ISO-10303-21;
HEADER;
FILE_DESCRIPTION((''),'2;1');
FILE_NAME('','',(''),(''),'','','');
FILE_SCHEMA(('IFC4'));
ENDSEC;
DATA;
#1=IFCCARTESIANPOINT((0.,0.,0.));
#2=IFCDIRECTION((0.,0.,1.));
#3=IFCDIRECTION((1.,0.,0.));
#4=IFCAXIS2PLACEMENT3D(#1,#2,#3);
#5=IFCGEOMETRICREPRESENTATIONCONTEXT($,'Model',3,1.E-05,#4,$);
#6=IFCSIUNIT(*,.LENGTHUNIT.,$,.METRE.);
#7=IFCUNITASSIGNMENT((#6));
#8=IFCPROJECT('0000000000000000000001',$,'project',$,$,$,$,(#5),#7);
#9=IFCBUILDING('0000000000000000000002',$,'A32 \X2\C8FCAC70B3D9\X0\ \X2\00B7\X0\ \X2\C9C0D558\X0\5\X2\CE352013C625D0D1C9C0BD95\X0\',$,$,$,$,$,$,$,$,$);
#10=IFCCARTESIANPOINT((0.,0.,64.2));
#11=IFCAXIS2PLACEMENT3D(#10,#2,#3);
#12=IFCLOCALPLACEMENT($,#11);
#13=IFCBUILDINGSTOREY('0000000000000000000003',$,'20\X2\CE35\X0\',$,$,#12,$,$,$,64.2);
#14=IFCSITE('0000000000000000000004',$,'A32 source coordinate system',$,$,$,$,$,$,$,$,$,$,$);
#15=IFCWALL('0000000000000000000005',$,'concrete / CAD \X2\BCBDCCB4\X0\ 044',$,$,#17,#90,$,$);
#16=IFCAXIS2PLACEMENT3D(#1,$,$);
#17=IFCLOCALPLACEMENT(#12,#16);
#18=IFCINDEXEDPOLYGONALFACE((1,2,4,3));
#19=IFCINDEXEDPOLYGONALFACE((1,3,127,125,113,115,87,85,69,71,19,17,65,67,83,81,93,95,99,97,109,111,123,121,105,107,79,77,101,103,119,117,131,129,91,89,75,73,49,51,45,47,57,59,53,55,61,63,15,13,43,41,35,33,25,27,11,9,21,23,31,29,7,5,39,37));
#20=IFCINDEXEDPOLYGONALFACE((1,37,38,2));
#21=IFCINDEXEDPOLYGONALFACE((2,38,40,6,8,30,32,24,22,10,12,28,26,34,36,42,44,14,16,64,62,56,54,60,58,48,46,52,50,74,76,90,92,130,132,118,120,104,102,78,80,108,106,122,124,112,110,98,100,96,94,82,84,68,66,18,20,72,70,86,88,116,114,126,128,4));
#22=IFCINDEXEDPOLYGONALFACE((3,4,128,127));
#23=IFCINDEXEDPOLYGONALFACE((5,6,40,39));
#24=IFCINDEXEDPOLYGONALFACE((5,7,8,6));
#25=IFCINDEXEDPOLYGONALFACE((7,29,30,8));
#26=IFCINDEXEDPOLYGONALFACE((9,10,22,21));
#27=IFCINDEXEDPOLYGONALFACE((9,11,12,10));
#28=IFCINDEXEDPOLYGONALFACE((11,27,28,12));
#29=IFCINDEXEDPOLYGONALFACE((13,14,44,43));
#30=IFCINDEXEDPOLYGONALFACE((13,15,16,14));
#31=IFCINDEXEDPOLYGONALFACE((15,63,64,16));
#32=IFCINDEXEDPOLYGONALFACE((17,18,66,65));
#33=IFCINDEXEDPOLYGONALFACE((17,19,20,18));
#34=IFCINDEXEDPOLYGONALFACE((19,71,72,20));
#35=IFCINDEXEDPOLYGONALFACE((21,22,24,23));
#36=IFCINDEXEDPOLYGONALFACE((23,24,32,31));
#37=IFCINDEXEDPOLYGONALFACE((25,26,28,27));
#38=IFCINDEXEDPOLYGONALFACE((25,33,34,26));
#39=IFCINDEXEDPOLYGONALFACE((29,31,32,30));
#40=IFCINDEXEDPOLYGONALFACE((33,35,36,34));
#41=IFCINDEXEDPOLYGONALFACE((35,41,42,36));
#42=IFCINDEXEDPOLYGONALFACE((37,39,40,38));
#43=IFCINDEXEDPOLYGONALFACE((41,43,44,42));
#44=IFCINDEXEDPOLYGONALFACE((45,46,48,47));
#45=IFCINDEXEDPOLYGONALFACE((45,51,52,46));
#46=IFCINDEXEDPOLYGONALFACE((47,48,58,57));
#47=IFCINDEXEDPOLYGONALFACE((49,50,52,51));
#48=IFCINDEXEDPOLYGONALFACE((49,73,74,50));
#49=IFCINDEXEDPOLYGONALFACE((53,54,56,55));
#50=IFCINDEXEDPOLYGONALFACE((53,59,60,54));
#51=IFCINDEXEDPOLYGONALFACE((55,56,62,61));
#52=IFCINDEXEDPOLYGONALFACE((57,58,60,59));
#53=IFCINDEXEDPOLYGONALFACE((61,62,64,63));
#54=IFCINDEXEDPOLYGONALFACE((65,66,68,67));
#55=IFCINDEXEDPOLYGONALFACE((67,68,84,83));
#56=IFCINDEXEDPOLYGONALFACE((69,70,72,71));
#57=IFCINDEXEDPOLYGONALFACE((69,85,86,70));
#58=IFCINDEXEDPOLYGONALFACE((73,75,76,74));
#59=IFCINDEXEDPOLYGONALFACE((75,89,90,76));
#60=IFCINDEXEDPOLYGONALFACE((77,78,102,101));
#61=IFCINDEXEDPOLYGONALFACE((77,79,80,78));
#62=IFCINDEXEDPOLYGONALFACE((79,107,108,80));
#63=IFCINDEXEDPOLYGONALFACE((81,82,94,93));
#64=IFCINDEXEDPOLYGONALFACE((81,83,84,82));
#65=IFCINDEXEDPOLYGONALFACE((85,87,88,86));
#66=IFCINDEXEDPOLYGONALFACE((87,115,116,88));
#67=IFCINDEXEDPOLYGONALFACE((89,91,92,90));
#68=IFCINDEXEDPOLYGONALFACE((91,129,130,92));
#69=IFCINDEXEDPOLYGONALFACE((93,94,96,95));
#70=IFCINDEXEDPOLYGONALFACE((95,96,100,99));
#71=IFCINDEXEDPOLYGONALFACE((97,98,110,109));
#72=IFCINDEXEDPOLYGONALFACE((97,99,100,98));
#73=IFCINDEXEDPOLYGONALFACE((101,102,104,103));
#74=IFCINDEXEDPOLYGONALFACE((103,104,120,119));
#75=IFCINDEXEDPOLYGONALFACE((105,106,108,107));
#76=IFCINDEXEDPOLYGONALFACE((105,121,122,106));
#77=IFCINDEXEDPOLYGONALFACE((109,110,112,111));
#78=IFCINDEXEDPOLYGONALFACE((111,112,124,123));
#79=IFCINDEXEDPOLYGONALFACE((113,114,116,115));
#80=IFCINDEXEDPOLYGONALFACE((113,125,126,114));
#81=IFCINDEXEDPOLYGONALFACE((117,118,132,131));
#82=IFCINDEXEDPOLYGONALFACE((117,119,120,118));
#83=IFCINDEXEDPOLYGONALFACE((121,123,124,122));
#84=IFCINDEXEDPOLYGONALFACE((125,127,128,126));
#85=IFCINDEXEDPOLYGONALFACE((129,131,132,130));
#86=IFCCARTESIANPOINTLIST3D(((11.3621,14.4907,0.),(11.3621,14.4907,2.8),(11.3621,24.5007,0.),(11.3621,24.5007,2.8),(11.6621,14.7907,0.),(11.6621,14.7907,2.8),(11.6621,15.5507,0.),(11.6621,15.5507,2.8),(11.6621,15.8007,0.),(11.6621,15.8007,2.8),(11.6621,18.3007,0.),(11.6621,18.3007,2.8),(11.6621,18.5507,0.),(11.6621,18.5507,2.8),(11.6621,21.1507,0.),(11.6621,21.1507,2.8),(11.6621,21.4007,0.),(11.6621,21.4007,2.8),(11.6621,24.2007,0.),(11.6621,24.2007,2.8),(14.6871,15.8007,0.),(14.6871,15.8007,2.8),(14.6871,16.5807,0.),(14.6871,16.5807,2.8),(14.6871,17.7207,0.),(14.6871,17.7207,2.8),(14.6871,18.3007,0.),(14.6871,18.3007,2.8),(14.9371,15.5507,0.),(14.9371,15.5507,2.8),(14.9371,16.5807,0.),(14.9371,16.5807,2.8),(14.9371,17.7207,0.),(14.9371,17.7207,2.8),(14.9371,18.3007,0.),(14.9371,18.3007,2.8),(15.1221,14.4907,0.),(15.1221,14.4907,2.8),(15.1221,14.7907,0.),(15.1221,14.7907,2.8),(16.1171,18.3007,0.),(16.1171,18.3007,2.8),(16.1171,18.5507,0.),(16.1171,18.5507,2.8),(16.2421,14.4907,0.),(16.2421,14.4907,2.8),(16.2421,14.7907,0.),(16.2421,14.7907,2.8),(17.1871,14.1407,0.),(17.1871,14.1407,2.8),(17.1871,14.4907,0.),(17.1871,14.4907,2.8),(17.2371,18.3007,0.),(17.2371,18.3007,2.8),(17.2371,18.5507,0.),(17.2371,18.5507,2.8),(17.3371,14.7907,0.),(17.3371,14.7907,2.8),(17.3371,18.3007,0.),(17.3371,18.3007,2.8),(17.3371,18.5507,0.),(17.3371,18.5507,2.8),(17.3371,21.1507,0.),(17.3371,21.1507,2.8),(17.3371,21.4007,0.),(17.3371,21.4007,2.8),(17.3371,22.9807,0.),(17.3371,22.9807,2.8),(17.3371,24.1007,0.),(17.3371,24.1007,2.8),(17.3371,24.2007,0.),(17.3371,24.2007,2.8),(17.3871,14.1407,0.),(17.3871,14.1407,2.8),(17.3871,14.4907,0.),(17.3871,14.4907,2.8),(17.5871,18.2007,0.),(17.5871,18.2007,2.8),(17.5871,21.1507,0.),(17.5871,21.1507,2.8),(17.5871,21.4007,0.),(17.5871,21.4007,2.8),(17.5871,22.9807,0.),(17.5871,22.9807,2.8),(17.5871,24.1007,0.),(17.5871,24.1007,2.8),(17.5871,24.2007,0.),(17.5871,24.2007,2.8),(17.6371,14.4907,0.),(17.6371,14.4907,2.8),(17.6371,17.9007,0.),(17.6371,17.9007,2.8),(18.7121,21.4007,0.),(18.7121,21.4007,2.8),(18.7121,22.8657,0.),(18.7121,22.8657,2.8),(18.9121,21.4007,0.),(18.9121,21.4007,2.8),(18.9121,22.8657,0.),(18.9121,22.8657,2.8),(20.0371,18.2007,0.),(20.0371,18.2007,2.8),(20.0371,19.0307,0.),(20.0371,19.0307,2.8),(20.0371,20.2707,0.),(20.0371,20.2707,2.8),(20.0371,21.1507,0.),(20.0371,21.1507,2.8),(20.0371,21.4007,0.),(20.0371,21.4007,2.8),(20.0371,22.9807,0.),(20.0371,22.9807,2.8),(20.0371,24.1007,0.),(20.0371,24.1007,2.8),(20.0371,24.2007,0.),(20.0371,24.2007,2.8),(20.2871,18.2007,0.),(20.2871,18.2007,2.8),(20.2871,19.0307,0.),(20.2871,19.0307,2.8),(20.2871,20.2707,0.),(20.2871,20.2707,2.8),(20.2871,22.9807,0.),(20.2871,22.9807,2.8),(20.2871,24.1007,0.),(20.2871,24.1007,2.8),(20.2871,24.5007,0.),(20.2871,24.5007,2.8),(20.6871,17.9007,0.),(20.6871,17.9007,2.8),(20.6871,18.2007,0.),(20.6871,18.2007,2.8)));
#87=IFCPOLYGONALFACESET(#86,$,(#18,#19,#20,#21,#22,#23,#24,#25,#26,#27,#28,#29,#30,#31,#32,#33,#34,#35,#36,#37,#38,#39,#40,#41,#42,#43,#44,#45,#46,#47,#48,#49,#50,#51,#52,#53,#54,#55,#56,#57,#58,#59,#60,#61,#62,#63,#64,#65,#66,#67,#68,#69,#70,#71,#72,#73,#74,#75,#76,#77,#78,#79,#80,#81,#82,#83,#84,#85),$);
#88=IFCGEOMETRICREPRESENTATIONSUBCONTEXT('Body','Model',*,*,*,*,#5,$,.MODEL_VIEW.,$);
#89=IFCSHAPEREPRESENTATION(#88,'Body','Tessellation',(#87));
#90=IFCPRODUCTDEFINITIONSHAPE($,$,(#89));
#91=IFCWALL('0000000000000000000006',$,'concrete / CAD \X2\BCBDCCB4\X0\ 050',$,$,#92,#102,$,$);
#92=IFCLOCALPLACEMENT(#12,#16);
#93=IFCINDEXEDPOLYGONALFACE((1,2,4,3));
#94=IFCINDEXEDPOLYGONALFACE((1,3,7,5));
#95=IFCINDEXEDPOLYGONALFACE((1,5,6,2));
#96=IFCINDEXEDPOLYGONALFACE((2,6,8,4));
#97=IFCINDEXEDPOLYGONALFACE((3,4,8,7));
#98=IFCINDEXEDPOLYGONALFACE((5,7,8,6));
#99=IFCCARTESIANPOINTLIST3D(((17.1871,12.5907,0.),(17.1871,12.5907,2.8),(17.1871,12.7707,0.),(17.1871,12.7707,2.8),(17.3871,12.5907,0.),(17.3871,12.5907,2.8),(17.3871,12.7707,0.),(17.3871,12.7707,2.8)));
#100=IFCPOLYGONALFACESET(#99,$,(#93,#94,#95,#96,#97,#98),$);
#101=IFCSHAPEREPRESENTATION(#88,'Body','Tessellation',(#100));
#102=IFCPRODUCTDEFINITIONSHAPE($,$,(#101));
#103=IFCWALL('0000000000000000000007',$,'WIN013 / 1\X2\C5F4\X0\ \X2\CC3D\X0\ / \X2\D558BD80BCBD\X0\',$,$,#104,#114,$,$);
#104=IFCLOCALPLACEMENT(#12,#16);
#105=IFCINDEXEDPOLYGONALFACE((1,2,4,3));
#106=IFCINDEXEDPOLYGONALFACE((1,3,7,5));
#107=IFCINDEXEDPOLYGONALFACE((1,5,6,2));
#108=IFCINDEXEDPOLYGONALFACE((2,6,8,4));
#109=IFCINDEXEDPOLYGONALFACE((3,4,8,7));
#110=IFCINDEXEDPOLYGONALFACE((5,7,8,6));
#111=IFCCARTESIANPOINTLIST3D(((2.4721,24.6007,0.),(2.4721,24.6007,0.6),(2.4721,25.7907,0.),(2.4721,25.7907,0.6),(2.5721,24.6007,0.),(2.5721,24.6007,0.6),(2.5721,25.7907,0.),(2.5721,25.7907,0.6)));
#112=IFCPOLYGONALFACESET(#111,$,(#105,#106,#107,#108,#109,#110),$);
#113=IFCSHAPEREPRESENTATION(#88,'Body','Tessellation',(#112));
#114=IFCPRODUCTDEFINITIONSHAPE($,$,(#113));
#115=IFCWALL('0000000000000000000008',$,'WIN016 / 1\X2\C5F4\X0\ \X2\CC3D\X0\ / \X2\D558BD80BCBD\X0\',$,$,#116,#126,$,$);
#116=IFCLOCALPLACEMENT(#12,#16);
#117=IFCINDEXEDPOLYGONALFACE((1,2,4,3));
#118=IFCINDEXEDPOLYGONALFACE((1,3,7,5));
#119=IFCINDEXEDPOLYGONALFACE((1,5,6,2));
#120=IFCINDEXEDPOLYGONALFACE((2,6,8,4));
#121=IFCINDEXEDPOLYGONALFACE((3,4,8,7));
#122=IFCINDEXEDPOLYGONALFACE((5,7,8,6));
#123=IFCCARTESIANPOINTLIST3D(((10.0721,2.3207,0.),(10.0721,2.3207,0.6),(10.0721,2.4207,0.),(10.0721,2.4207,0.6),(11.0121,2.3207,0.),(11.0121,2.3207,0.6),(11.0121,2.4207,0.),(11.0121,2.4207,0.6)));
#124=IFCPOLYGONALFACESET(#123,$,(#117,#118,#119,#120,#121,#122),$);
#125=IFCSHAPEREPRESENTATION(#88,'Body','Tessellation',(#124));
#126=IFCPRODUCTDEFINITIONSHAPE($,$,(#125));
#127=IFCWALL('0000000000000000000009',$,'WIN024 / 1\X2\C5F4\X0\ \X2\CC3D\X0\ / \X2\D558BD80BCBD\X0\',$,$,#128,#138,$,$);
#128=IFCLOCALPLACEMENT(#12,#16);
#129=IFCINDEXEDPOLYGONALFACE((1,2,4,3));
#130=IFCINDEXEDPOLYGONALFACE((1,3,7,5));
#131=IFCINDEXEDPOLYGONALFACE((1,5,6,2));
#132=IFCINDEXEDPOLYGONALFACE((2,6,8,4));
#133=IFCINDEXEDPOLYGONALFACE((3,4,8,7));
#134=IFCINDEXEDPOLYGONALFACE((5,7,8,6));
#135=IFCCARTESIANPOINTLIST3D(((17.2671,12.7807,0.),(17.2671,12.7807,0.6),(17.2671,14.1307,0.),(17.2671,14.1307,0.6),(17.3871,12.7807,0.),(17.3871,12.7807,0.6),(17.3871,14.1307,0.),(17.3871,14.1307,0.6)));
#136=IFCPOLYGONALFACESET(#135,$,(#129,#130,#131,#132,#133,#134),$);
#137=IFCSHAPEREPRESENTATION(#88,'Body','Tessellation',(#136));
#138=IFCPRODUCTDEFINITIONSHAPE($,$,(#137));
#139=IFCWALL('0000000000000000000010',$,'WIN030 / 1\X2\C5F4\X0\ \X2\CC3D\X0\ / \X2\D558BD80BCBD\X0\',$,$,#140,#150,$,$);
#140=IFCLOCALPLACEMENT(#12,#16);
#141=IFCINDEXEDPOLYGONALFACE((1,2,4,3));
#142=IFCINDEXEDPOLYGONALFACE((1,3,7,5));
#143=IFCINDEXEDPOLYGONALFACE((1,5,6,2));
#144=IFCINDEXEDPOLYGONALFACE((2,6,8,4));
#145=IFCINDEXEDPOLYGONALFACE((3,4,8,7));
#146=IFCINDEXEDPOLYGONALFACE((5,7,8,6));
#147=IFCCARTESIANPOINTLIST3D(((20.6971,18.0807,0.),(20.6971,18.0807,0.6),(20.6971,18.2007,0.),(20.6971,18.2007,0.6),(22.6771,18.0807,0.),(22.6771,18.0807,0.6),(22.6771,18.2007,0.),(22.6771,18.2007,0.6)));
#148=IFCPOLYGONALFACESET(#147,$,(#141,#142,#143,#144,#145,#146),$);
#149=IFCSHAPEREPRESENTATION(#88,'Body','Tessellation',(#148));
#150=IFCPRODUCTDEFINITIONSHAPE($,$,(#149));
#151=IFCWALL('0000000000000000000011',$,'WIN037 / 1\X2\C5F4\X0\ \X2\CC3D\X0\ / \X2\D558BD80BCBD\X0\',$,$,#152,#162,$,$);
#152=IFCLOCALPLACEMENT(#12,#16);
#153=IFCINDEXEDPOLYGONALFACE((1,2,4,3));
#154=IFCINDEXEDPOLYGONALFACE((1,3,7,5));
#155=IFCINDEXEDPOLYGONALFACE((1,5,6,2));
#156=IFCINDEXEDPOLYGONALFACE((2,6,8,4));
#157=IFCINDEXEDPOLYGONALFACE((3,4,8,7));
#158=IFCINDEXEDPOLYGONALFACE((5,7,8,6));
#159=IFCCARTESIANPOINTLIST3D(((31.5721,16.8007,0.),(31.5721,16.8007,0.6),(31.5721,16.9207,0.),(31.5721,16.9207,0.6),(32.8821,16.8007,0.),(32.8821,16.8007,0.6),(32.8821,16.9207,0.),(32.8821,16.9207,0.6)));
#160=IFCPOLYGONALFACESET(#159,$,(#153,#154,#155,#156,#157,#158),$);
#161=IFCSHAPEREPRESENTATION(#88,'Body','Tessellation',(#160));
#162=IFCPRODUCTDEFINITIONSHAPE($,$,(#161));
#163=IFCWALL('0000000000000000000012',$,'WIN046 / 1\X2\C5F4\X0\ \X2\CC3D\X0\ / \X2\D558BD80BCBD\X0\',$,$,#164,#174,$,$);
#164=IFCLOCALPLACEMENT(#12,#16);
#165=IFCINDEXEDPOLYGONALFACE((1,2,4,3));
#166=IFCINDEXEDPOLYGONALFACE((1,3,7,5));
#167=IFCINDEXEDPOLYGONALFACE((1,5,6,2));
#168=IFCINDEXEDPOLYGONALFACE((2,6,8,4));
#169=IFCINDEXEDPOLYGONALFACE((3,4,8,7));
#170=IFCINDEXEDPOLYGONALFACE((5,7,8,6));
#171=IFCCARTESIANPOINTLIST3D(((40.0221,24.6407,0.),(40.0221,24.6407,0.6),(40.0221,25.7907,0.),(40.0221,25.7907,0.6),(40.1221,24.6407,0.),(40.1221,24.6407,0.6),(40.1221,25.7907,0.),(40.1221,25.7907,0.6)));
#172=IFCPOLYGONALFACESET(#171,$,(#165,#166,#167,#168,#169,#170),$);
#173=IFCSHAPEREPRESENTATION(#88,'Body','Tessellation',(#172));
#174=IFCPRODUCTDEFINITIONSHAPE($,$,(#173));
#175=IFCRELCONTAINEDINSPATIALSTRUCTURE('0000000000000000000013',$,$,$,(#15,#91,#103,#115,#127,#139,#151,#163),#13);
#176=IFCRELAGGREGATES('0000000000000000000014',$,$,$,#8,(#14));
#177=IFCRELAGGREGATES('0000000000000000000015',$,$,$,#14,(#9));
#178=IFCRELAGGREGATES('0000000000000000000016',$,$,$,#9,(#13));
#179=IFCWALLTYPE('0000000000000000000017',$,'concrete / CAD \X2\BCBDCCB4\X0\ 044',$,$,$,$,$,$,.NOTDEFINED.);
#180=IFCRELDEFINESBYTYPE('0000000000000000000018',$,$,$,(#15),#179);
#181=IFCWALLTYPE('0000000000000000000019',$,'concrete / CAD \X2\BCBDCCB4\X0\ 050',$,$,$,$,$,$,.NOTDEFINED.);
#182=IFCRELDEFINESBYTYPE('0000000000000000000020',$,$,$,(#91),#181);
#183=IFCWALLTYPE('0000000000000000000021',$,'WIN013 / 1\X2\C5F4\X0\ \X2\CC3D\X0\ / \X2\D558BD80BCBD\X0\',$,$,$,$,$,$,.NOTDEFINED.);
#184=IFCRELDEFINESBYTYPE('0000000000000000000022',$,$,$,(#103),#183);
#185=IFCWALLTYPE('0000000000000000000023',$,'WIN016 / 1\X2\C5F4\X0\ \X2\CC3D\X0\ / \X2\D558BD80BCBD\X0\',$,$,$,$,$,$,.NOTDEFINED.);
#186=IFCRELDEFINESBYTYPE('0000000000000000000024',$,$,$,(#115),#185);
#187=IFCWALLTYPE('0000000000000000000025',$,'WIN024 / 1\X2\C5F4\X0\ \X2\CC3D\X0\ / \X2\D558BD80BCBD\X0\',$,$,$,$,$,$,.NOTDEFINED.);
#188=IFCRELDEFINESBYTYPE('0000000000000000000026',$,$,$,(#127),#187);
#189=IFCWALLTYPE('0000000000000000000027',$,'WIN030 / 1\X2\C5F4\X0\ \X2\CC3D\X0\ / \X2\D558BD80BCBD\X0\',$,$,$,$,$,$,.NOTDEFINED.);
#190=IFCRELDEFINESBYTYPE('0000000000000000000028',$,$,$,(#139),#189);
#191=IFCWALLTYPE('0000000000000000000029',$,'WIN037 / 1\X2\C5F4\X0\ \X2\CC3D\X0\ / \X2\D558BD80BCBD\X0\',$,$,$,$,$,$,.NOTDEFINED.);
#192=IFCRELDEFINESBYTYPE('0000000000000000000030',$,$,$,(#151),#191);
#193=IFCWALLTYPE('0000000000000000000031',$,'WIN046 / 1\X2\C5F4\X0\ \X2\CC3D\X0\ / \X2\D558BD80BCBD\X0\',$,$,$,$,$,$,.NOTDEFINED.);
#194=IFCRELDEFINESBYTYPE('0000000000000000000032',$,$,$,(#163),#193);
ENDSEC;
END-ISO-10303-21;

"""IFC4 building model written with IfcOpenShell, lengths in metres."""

from ifc_helpers import new_model, si_unit, frame, origin, origin_with_axes, place, context, subcontext, project, spatial, polyline, outline, extrude, source, transform, mapped, type_object, type_shapes, element, save


model = new_model("IFC4")

# Units and contexts
model_context = context("Model", 3, precision=1e-05, world=origin_with_axes())
body_context = subcontext(model_context, "Body", "Model", "MODEL_VIEW")
ifc_project = project(units=[si_unit("LENGTHUNIT", "METRE")], contexts=[model_context])

# Site, building, storey
site = spatial("IfcSite", under=ifc_project, Name="A32 source coordinate system")
building = spatial("IfcBuilding", under=site, Name="A32 주거동 · 지하5층–옥탑지붕")
storey_placement = place(None, frame((0.0, 0.0, 64.2), z_axis=(0.0, 0.0, 1.0), x_axis=(1.0, 0.0, 0.0)))
storey = spatial("IfcBuildingStorey", under=building, at=storey_placement, Name="20층", Elevation=64.2)

# Walls
wall_type_1 = type_object("IfcWallType", Name="concrete / CAD 벽체 044", PredefinedType="NOTDEFINED")
shared_shape_1 = source(origin(), body_context, "Body", "SweptSolid", [
    extrude(outline(polyline([(17.3371, 21.4007), (17.3371, 22.9807), (17.5871, 22.9807), (17.5871, 21.4007), (18.7121, 21.4007), (18.7121, 22.8657), (18.9121, 22.8657), (18.9121, 21.4007), (20.0371, 21.4007), (20.0371, 22.9807), (20.2871, 22.9807), (20.2871, 20.2707), (20.0371, 20.2707), (20.0371, 21.1507), (17.5871, 21.1507), (17.5871, 18.2007), (20.0371, 18.2007), (20.0371, 19.0307), (20.2871, 19.0307), (20.2871, 18.2007), (20.6871, 18.2007), (20.6871, 17.9007), (17.6371, 17.9007), (17.6371, 14.4907), (17.3871, 14.4907), (17.3871, 14.1407), (17.1871, 14.1407), (17.1871, 14.4907), (16.2421, 14.4907), (16.2421, 14.7907), (17.3371, 14.7907), (17.3371, 18.3007), (17.2371, 18.3007), (17.2371, 18.5507), (17.3371, 18.5507), (17.3371, 21.1507), (11.6621, 21.1507), (11.6621, 18.5507), (16.1171, 18.5507), (16.1171, 18.3007), (14.9371, 18.3007), (14.9371, 17.7207), (14.6871, 17.7207), (14.6871, 18.3007), (11.6621, 18.3007), (11.6621, 15.8007), (14.6871, 15.8007), (14.6871, 16.5807), (14.9371, 16.5807), (14.9371, 15.5507), (11.6621, 15.5507), (11.6621, 14.7907), (15.1221, 14.7907), (15.1221, 14.4907), (11.3621, 14.4907), (11.3621, 24.5007), (20.2871, 24.5007), (20.2871, 24.1007), (20.0371, 24.1007), (20.0371, 24.2007), (17.5871, 24.2007), (17.5871, 24.1007), (17.3371, 24.1007), (17.3371, 24.2007), (11.6621, 24.2007), (11.6621, 21.4007), (17.3371, 21.4007)])), origin(), (0.0, 0.0, 1.0), 2.8),
])
type_shapes(wall_type_1, [shared_shape_1])
wall_1_placement = place(storey_placement, origin_with_axes())
element("IfcWall", 1, at=wall_1_placement, inside=storey, type_object=wall_type_1, Name="concrete / CAD 벽체 044", context=body_context, shape_type="MappedRepresentation", body=[
    mapped(shared_shape_1, transform((0.0, 0.0, 0.0), scale=1.0)),
])
wall_type_2 = type_object("IfcWallType", Name="concrete / CAD 벽체 050", PredefinedType="NOTDEFINED")
shared_shape_2 = source(origin(), body_context, "Body", "SweptSolid", [
    extrude(outline(polyline([(17.3871, 12.5907), (17.1871, 12.5907), (17.1871, 12.7707), (17.3871, 12.7707), (17.3871, 12.5907)])), origin(), (0.0, 0.0, 1.0), 2.8),
])
type_shapes(wall_type_2, [shared_shape_2])
wall_2_placement = place(storey_placement, origin_with_axes())
element("IfcWall", 2, at=wall_2_placement, inside=storey, type_object=wall_type_2, Name="concrete / CAD 벽체 050", context=body_context, shape_type="MappedRepresentation", body=[
    mapped(shared_shape_2, transform((0.0, 0.0, 0.0), scale=1.0)),
])
wall_type_3 = type_object("IfcWallType", Name="WIN013 / 1열 창 / 하부벽", PredefinedType="NOTDEFINED")
shared_shape_3 = source(origin(), body_context, "Body", "SweptSolid", [
    extrude(outline(polyline([(2.5721, 25.7907), (2.5721, 24.6007), (2.4721, 24.6007), (2.4721, 25.7907), (2.5721, 25.7907)])), origin(), (0.0, 0.0, 1.0), 0.6),
])
type_shapes(wall_type_3, [shared_shape_3])
wall_3_placement = place(storey_placement, origin_with_axes())
element("IfcWall", 3, at=wall_3_placement, inside=storey, type_object=wall_type_3, Name="WIN013 / 1열 창 / 하부벽", context=body_context, shape_type="MappedRepresentation", body=[
    mapped(shared_shape_3, transform((0.0, 0.0, 0.0), scale=1.0)),
])
wall_type_4 = type_object("IfcWallType", Name="WIN016 / 1열 창 / 하부벽", PredefinedType="NOTDEFINED")
shared_shape_4 = source(origin(), body_context, "Body", "SweptSolid", [
    extrude(outline(polyline([(11.0121, 2.4207), (11.0121, 2.3207), (10.0721, 2.3207), (10.0721, 2.4207), (11.0121, 2.4207)])), origin(), (0.0, 0.0, 1.0), 0.6),
])
type_shapes(wall_type_4, [shared_shape_4])
wall_4_placement = place(storey_placement, origin_with_axes())
element("IfcWall", 4, at=wall_4_placement, inside=storey, type_object=wall_type_4, Name="WIN016 / 1열 창 / 하부벽", context=body_context, shape_type="MappedRepresentation", body=[
    mapped(shared_shape_4, transform((0.0, 0.0, 0.0), scale=1.0)),
])
wall_type_5 = type_object("IfcWallType", Name="WIN024 / 1열 창 / 하부벽", PredefinedType="NOTDEFINED")
shared_shape_5 = source(origin(), body_context, "Body", "SweptSolid", [
    extrude(outline(polyline([(17.3871, 14.1307), (17.3871, 12.7807), (17.2671, 12.7807), (17.2671, 14.1307), (17.3871, 14.1307)])), origin(), (0.0, 0.0, 1.0), 0.6),
])
type_shapes(wall_type_5, [shared_shape_5])
wall_5_placement = place(storey_placement, origin_with_axes())
element("IfcWall", 5, at=wall_5_placement, inside=storey, type_object=wall_type_5, Name="WIN024 / 1열 창 / 하부벽", context=body_context, shape_type="MappedRepresentation", body=[
    mapped(shared_shape_5, transform((0.0, 0.0, 0.0), scale=1.0)),
])
wall_type_6 = type_object("IfcWallType", Name="WIN030 / 1열 창 / 하부벽", PredefinedType="NOTDEFINED")
shared_shape_6 = source(origin(), body_context, "Body", "SweptSolid", [
    extrude(outline(polyline([(22.6771, 18.2007), (22.6771, 18.0807), (20.6971, 18.0807), (20.6971, 18.2007), (22.6771, 18.2007)])), origin(), (0.0, 0.0, 1.0), 0.6),
])
type_shapes(wall_type_6, [shared_shape_6])
wall_6_placement = place(storey_placement, origin_with_axes())
element("IfcWall", 6, at=wall_6_placement, inside=storey, type_object=wall_type_6, Name="WIN030 / 1열 창 / 하부벽", context=body_context, shape_type="MappedRepresentation", body=[
    mapped(shared_shape_6, transform((0.0, 0.0, 0.0), scale=1.0)),
])
wall_type_7 = type_object("IfcWallType", Name="WIN037 / 1열 창 / 하부벽", PredefinedType="NOTDEFINED")
shared_shape_7 = source(origin(), body_context, "Body", "SweptSolid", [
    extrude(outline(polyline([(32.8821, 16.9207), (32.8821, 16.8007), (31.5721, 16.8007), (31.5721, 16.9207), (32.8821, 16.9207)])), origin(), (0.0, 0.0, 1.0), 0.6),
])
type_shapes(wall_type_7, [shared_shape_7])
wall_7_placement = place(storey_placement, origin_with_axes())
element("IfcWall", 7, at=wall_7_placement, inside=storey, type_object=wall_type_7, Name="WIN037 / 1열 창 / 하부벽", context=body_context, shape_type="MappedRepresentation", body=[
    mapped(shared_shape_7, transform((0.0, 0.0, 0.0), scale=1.0)),
])
wall_type_8 = type_object("IfcWallType", Name="WIN046 / 1열 창 / 하부벽", PredefinedType="NOTDEFINED")
shared_shape_8 = source(origin(), body_context, "Body", "SweptSolid", [
    extrude(outline(polyline([(40.1221, 25.7907), (40.1221, 24.6407), (40.0221, 24.6407), (40.0221, 25.7907), (40.1221, 25.7907)])), origin(), (0.0, 0.0, 1.0), 0.6),
])
type_shapes(wall_type_8, [shared_shape_8])
wall_8_placement = place(storey_placement, origin_with_axes())
element("IfcWall", 8, at=wall_8_placement, inside=storey, type_object=wall_type_8, Name="WIN046 / 1열 창 / 하부벽", context=body_context, shape_type="MappedRepresentation", body=[
    mapped(shared_shape_8, transform((0.0, 0.0, 0.0), scale=1.0)),
])

save(model, "model.ifc")
